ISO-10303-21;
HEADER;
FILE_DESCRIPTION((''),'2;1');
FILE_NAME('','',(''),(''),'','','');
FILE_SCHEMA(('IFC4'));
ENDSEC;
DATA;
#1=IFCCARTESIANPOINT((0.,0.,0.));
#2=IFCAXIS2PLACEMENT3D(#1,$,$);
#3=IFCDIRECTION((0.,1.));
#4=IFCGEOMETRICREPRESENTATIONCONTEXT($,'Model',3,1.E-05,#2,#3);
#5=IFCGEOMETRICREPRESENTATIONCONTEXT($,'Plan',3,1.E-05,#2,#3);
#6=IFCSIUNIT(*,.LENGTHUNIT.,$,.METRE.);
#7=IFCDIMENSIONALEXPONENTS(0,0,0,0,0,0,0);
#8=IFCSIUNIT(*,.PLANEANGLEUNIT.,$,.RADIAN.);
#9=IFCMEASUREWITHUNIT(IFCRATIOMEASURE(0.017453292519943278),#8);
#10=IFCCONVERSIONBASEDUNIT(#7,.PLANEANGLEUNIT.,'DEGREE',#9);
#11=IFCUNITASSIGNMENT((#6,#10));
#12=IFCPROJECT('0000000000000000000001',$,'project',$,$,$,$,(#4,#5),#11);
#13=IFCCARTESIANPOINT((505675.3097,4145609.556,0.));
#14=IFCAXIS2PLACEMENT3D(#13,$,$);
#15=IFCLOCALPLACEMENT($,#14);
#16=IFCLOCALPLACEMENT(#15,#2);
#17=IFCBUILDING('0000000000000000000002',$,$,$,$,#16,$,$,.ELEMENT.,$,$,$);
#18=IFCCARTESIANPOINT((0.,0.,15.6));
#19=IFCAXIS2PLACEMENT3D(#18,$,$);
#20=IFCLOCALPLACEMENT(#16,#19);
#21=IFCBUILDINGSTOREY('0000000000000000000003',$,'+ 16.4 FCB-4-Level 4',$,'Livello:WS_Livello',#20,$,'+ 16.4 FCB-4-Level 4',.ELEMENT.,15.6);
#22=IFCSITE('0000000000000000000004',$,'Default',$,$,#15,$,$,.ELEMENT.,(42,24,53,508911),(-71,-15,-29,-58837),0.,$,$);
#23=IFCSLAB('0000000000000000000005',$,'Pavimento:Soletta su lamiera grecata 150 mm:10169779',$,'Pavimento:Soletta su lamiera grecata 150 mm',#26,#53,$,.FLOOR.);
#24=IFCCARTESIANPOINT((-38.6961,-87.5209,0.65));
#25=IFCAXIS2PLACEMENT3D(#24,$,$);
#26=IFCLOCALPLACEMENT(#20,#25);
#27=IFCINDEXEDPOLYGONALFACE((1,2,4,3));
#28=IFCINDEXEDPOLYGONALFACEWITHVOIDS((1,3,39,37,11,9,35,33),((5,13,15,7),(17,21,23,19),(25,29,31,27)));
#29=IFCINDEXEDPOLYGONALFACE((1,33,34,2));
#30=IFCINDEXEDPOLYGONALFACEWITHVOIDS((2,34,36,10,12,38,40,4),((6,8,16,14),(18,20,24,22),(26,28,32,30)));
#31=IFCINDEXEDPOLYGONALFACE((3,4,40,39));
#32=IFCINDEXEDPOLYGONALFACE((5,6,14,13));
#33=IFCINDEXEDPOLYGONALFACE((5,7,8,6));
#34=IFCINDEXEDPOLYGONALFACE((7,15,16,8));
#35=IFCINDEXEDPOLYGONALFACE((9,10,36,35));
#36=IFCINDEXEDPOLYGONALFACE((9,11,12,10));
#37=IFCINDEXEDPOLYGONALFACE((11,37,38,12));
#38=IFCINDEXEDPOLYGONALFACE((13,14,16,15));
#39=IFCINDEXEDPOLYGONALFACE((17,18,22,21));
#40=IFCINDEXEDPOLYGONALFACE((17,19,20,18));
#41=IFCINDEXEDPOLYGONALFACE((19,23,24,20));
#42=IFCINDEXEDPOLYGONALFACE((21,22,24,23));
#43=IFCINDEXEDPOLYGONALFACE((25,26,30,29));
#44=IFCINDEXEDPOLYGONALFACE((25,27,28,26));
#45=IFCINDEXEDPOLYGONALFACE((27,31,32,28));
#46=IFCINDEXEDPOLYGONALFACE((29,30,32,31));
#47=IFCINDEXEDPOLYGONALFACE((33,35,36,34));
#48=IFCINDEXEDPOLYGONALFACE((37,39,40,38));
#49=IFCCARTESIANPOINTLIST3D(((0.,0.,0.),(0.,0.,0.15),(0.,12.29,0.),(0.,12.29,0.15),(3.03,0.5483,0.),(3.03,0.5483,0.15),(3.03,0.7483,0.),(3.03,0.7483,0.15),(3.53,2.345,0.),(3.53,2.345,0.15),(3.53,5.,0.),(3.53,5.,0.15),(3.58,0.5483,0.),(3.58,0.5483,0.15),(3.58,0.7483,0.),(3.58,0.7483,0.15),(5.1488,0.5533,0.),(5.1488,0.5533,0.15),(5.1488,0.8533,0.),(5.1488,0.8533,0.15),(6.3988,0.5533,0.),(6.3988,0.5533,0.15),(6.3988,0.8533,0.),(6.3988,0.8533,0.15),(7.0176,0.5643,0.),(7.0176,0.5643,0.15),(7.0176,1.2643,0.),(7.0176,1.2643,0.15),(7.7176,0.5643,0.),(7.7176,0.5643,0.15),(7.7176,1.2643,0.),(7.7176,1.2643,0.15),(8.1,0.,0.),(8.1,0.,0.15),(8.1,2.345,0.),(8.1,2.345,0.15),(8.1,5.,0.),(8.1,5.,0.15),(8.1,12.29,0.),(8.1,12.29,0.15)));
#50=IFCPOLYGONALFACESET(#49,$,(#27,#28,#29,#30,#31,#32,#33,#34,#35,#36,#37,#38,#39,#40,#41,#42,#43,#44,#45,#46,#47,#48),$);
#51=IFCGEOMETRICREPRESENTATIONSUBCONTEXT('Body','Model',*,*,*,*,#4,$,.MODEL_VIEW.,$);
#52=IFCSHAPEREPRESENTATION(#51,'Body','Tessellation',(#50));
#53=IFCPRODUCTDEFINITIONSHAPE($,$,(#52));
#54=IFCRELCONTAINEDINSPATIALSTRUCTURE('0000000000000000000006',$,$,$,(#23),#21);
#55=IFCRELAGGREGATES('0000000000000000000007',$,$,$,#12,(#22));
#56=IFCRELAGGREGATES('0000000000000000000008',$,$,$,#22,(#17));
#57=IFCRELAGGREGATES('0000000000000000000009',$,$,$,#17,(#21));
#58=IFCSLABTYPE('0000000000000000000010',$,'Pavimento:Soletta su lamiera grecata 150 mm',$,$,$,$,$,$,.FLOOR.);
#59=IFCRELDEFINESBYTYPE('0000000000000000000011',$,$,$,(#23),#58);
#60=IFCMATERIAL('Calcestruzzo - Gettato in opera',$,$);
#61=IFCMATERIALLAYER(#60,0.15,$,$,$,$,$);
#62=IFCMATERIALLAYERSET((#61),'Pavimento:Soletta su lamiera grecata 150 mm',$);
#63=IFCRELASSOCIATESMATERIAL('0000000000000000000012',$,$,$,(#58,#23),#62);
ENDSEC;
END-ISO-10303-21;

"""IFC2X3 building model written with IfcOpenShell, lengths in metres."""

from ifc_helpers import new_model, entity, si_unit, converted_unit, direction, frame, frame_2d, origin, origin_2d_with_axis, place, context, subcontext, project, spatial, polyline, rectangle, outline, extrude, material, layer, layer_set, layer_usage, type_object, element, save


model = new_model("IFC2X3")

# Units and contexts
model_context = context("Model", 3, precision=1e-05, world=origin(), true_north=direction((0.0, 1.0)))
plan_context = context("Plan", 3, precision=1e-05, world=origin(), true_north=direction((0.0, 1.0)))
body_context = subcontext(model_context, "Body", "Model", "MODEL_VIEW")
ifc_project = project(units=[si_unit("LENGTHUNIT", "METRE"), converted_unit("PLANEANGLEUNIT", "DEGREE", entity("IfcRatioMeasure", 0.017453292519943278), si_unit("PLANEANGLEUNIT", "RADIAN"), dimensions=[0, 0, 0, 0, 0, 0, 0])], contexts=[model_context, plan_context])

# Site, building, storey
site_placement = place(None, frame((505675.3097, 4145609.556, 0.0)))
site = spatial("IfcSite", under=ifc_project, at=site_placement, Name="Default", CompositionType="ELEMENT", RefLatitude=(42, 24, 53, 508911), RefLongitude=(-71, -15, -29, -58837), RefElevation=0.0)
building_placement = place(site_placement, origin())
building = spatial("IfcBuilding", under=site, at=building_placement, CompositionType="ELEMENT")
storey_placement = place(building_placement, frame((0.0, 0.0, 15.6)))
storey = spatial("IfcBuildingStorey", under=building, at=storey_placement, Name="+ 16.4 FCB-4-Level 4", ObjectType="Livello:WS_Livello", LongName="+ 16.4 FCB-4-Level 4", CompositionType="ELEMENT", Elevation=15.6)

# Shared definitions
ifc_material_1 = material(Name="Calcestruzzo - Gettato in opera")

# Slab, openings
ifc_layer_1 = layer(ifc_material_1, 0.15)
ifc_layer_set_1 = layer_set([ifc_layer_1], Name="Pavimento:Soletta su lamiera grecata 150 mm")
ifc_layer_usage_1 = layer_usage(ifc_layer_set_1, "AXIS3", "POSITIVE", 0.0)
slab_type_1 = type_object("IfcSlabType", Name="Pavimento:Soletta su lamiera grecata 150 mm", PredefinedType="FLOOR", material=ifc_layer_set_1)
slab_1_placement = place(storey_placement, frame((-38.6961, -87.5209, 0.65)))
slab_1 = element("IfcSlab", 1, at=slab_1_placement, inside=storey, type_object=slab_type_1, material=ifc_layer_usage_1, Name="Pavimento:Soletta su lamiera grecata 150 mm:10169779", ObjectType="Pavimento:Soletta su lamiera grecata 150 mm", PredefinedType="FLOOR", context=body_context, shape_type="SweptSolid", body=[
    extrude(outline(polyline([(-4.05, 6.145), (-4.05, -1.145), (0.52, -1.145), (0.52, -3.8), (-4.05, -3.8), (-4.05, -6.145), (4.05, -6.145), (4.05, 6.145), (-4.05, 6.145)])), frame((4.05, 6.145, 0.15), z_axis=(0.0, 0.0, -1.0), x_axis=(-1.0, 0.0, 0.0)), (0.0, 0.0, 1.0), 0.15),
])
opening_1_placement = place(slab_1_placement, origin())
element("IfcOpeningElement", 2, at=opening_1_placement, cuts=slab_1, ObjectType="Opening", context=body_context, shape_type="SweptSolid", body=[
    extrude(rectangle(XDim=0.2, YDim=0.55, at=frame_2d((0.0, 0.0), x_axis=(1.0, 0.0))), frame((3.305, 0.6483, 0.15), z_axis=(0.0, 0.0, -1.0), x_axis=(0.0, -1.0, 0.0)), (0.0, 0.0, 1.0), 0.15),
])
opening_2_placement = place(slab_1_placement, origin())
element("IfcOpeningElement", 3, at=opening_2_placement, cuts=slab_1, ObjectType="Opening", context=body_context, shape_type="SweptSolid", body=[
    extrude(rectangle(XDim=1.25, YDim=0.3, at=origin_2d_with_axis()), frame((5.7738, 0.7033, 0.15), z_axis=(0.0, 0.0, -1.0), x_axis=(1.0, 0.0, 0.0)), (0.0, 0.0, 1.0), 0.15),
])
opening_3_placement = place(slab_1_placement, origin())
element("IfcOpeningElement", 4, at=opening_3_placement, cuts=slab_1, ObjectType="Opening", context=body_context, shape_type="SweptSolid", body=[
    extrude(rectangle(XDim=0.7, YDim=0.7, at=frame_2d((0.0, 0.0), x_axis=(1.0, 0.0))), frame((7.3676, 0.9143, 0.15), z_axis=(0.0, 0.0, -1.0), x_axis=(1.0, 0.0, 0.0)), (0.0, 0.0, 1.0), 0.15),
])

save(model, "model.ifc")
